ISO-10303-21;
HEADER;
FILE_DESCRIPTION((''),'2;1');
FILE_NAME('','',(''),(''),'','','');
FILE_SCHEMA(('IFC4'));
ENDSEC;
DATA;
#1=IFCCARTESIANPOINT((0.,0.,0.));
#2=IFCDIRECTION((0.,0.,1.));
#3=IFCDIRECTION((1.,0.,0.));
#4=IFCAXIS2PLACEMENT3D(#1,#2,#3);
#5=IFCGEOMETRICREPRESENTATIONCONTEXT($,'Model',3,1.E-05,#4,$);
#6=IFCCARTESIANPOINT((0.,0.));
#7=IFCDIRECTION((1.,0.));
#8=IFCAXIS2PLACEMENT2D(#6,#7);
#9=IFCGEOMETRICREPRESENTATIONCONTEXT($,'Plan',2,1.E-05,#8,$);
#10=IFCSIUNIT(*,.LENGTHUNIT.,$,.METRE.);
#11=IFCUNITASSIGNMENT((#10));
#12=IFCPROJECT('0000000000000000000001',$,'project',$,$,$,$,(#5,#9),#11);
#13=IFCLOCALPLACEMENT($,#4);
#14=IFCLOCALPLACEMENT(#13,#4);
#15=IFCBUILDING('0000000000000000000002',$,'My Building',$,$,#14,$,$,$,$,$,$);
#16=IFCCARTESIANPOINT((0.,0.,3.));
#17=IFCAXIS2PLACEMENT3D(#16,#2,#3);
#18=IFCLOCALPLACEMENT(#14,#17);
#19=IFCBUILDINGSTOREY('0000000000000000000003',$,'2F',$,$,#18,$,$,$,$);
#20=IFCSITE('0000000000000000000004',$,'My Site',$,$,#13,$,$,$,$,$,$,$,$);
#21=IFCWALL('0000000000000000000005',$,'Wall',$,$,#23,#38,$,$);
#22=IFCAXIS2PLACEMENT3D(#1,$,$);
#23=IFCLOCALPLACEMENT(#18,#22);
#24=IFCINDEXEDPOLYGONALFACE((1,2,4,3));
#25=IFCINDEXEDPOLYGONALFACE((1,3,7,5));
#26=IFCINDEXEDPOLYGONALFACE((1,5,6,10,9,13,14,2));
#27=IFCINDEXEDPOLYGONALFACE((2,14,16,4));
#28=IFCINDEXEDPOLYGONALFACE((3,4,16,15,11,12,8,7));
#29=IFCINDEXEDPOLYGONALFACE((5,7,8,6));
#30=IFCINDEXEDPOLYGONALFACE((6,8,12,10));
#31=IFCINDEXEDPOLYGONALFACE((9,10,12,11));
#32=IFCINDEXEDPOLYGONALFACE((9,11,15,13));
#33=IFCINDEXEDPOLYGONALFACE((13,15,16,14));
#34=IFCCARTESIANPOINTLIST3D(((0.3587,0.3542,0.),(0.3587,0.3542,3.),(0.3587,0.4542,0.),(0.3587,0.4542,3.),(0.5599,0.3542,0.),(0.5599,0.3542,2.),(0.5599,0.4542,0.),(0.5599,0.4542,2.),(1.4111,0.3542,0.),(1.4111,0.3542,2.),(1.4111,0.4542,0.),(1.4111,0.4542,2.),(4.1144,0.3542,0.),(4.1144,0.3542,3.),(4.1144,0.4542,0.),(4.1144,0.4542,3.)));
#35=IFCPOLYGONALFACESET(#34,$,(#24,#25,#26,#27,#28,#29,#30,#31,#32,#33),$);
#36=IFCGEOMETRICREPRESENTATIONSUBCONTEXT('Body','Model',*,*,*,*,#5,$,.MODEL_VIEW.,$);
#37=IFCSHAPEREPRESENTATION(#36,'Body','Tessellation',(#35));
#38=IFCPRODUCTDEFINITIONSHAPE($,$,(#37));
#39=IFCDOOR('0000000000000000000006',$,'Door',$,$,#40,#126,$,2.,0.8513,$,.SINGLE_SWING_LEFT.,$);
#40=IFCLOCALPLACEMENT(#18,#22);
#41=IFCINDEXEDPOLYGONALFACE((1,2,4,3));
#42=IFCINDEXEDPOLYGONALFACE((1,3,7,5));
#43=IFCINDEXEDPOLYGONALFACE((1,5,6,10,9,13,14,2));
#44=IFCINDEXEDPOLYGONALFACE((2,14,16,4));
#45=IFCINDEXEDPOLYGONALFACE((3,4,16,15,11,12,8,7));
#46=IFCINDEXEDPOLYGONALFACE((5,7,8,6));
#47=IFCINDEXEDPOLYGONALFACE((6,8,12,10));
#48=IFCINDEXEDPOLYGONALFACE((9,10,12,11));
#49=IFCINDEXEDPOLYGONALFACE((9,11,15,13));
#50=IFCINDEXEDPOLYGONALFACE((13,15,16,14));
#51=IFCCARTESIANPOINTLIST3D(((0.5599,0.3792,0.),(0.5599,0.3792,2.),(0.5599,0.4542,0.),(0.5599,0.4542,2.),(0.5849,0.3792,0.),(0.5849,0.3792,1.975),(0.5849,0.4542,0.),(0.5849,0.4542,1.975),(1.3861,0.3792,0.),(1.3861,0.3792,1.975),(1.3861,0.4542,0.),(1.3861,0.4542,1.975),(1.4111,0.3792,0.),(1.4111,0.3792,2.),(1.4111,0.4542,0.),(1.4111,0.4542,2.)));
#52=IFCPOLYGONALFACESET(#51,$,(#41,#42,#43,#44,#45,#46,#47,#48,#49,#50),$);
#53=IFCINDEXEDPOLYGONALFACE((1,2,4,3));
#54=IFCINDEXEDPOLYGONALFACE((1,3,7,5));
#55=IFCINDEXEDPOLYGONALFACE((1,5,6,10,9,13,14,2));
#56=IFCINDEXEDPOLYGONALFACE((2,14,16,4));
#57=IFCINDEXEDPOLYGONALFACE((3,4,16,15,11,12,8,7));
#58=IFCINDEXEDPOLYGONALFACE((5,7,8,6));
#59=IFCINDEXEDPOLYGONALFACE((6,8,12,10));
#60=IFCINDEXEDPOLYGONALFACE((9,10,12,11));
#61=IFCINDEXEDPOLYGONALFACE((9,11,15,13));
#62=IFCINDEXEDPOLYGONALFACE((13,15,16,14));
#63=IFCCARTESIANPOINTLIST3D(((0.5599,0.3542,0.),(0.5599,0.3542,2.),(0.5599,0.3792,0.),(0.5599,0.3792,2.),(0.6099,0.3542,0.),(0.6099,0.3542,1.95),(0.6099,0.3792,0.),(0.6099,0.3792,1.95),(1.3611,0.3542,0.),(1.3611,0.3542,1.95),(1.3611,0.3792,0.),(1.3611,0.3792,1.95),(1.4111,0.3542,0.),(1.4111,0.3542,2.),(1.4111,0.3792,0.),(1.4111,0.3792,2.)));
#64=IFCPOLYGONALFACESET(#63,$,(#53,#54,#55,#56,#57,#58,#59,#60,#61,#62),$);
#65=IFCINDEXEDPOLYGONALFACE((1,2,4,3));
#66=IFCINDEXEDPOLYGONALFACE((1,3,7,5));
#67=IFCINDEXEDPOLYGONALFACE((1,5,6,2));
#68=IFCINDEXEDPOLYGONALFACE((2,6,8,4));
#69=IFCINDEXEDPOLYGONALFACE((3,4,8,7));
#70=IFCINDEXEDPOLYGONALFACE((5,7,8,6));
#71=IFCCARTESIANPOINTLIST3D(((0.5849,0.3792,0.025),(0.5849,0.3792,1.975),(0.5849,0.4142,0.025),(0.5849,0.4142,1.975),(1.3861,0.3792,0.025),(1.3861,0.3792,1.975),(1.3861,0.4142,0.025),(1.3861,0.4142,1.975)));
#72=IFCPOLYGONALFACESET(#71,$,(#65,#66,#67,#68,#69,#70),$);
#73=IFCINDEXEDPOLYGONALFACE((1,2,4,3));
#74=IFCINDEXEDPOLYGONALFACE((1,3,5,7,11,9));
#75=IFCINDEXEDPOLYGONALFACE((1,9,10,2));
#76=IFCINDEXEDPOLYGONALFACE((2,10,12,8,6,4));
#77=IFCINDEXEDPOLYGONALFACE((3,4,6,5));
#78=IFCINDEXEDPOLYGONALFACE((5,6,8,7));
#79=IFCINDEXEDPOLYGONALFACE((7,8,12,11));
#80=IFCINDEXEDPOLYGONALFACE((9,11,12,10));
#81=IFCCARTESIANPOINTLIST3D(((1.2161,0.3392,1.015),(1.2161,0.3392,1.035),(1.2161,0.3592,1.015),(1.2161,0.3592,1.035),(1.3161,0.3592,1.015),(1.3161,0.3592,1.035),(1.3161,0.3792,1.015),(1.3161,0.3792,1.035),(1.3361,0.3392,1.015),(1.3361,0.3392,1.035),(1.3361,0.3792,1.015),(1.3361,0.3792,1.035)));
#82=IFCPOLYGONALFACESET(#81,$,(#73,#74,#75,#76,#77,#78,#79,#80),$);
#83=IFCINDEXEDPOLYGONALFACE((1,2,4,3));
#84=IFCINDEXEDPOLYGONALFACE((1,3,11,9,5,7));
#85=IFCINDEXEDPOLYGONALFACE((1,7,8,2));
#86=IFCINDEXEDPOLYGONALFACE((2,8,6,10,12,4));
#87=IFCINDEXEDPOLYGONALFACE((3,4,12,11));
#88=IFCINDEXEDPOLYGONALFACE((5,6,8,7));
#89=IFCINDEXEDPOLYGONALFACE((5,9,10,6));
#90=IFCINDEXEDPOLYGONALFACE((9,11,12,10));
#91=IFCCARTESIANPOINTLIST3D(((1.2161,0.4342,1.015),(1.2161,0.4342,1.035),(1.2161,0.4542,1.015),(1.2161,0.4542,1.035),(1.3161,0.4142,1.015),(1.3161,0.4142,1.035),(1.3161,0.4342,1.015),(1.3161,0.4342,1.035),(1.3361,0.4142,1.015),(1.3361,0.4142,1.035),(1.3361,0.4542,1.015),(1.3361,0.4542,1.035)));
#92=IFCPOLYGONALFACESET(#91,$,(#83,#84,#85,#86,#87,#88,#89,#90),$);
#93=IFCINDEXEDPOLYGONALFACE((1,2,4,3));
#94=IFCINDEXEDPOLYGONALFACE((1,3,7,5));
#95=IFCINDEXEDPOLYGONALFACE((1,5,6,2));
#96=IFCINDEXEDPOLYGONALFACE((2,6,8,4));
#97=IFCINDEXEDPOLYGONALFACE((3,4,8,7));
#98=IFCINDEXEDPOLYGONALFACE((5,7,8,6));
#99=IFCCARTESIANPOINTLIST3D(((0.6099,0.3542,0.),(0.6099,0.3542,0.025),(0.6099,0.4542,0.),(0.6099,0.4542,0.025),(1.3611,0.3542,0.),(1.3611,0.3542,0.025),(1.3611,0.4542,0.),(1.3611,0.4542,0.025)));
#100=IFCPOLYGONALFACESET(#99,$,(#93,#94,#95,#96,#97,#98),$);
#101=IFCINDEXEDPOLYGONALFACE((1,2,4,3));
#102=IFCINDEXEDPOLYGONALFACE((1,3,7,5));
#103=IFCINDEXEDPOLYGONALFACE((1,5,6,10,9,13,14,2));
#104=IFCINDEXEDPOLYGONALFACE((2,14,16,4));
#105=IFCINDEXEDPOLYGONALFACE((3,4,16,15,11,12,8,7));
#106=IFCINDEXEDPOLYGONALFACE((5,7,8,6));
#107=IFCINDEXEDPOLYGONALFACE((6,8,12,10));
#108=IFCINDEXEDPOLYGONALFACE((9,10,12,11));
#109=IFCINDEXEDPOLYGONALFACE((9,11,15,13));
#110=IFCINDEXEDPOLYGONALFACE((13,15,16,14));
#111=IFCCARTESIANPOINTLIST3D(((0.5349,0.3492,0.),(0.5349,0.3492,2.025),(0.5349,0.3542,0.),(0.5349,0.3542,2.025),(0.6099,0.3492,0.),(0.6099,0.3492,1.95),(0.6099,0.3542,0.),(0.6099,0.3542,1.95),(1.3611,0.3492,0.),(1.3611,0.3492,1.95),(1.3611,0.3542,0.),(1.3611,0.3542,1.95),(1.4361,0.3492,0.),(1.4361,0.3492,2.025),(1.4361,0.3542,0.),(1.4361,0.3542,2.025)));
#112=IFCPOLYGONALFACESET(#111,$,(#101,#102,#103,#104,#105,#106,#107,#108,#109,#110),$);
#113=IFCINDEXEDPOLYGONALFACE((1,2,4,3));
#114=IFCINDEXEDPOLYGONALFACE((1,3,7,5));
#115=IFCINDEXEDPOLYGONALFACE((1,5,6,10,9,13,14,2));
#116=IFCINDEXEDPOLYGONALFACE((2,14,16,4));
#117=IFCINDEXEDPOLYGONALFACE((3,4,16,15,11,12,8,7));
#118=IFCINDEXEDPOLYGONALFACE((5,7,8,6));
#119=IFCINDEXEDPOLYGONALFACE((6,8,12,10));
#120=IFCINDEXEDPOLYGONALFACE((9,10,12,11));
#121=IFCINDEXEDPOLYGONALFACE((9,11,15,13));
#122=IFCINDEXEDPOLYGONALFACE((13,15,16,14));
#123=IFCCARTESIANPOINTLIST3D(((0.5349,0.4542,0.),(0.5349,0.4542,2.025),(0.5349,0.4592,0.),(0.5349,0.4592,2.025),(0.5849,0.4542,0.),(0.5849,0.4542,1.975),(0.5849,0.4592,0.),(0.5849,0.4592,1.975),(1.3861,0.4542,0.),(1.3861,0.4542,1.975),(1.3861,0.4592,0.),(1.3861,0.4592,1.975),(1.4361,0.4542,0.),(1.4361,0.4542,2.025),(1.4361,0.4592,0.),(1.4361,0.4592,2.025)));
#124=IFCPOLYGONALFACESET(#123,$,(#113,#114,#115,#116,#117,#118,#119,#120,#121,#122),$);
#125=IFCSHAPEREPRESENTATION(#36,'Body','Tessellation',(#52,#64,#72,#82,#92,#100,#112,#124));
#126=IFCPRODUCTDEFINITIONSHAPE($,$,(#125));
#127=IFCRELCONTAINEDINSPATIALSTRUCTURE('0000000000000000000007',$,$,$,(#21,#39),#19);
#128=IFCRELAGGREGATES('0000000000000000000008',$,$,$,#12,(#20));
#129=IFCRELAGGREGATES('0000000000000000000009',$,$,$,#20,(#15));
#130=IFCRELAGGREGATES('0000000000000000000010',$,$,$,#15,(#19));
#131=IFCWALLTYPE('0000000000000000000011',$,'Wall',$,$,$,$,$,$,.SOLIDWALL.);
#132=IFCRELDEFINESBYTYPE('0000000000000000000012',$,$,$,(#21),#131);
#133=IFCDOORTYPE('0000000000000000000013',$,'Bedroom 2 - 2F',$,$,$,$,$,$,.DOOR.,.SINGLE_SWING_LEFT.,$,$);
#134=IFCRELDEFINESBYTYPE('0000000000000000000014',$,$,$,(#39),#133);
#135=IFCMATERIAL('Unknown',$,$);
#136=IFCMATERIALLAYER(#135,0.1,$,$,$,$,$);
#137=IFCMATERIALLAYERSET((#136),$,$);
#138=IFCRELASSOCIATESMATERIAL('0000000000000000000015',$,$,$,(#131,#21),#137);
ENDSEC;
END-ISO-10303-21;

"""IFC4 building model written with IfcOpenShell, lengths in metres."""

from ifc_helpers import new_model, entity, si_unit, frame, origin_with_axes, origin_2d_with_axis, place, context, subcontext, project, spatial, line, indexed_curve, outline, extrude, shape, source, transform, mapped, material, layer, layer_set, layer_usage, type_object, type_shapes, element, fill, save


model = new_model("IFC4")

# Units and contexts
model_context = context("Model", 3, precision=1e-05, world=origin_with_axes())
plan_context = context("Plan", 2, precision=1e-05, world=origin_2d_with_axis())
body_context_1 = subcontext(model_context, "Body", "Model", "MODEL_VIEW")
body_context_2 = subcontext(plan_context, "Body", "Plan", "PLAN_VIEW")
ifc_project = project(units=[si_unit("LENGTHUNIT", "METRE")], contexts=[model_context, plan_context])

# Site, building, storey
site_placement = place(None, origin_with_axes())
site = spatial("IfcSite", under=ifc_project, at=site_placement, Name="My Site")
building_placement = place(site_placement, origin_with_axes())
building = spatial("IfcBuilding", under=site, at=building_placement, Name="My Building")
storey_placement = place(building_placement, frame((0.0, 0.0, 3.0), z_axis=(0.0, 0.0, 1.0), x_axis=(1.0, 0.0, 0.0)))
storey = spatial("IfcBuildingStorey", under=building, at=storey_placement, Name="2F")

# Shared definitions
ifc_material = material(Name="Unknown")

# Shared definitions
ifc_layer_1 = layer(ifc_material, 0.1)
ifc_layer_set_1 = layer_set([ifc_layer_1])
wall_type = type_object("IfcWallType", Name="Wall", PredefinedType="SOLIDWALL", material=ifc_layer_set_1)

# Shared definitions
shared_shape_1 = source(origin_with_axes(), body_context_1, "Body", "SweptSolid", [
    extrude(outline(indexed_curve([(0.0, 0.0), (0.8513, 0.0), (0.8513, 2.0), (0.0, 2.0)], segments=[line(1, 2, 3, 4, 1)])), frame((0.0, -0.6, 0.0), z_axis=(0.0, -1.0, 0.0), x_axis=(1.0, 0.0, 0.0)), (0.0, 0.0, -1.0), 1.2),
])
door_type_1 = type_object("IfcDoorType", Name="Bedroom 2 - 2F", OperationType="SINGLE_SWING_LEFT", PredefinedType="DOOR")
shared_shape_2 = source(origin_with_axes(), body_context_1, "Body", "SweptSolid", [
    extrude(outline(indexed_curve([(0.0, 0.0), (0.0, 2.0), (0.8513, 2.0), (0.8513, 0.0), (0.8263, 0.0), (0.8263, 1.975), (0.025, 1.975), (0.025, 0.0)], segments=[line(1, 2, 3, 4, 5, 6, 7, 8, 1)])), frame((0.0, 0.025, 0.0), z_axis=(0.0, -1.0, 0.0), x_axis=(1.0, 0.0, 0.0)), (0.0, 0.0, -1.0), 0.075),
    extrude(outline(indexed_curve([(0.0, 0.0), (0.0, 2.0), (0.8513, 2.0), (0.8513, 0.0), (0.8013, 0.0), (0.8013, 1.95), (0.05, 1.95), (0.05, 0.0)], segments=[line(1, 2, 3, 4, 5, 6, 7, 8, 1)])), frame((0.0, 0.0, 0.0), z_axis=(0.0, -1.0, 0.0), x_axis=(1.0, 0.0, 0.0)), (0.0, 0.0, -1.0), 0.025),
    extrude(outline(indexed_curve([(0.0, 0.0), (0.8013, 0.0), (0.8013, 0.035), (0.0, 0.035)], segments=[line(1, 2, 3, 4, 1)])), frame((0.025, 0.025, 0.025), z_axis=(0.0, 0.0, 1.0), x_axis=(1.0, 0.0, 0.0)), (0.0, 0.0, 1.0), 1.95),
    extrude(outline(indexed_curve([(0.0, 0.0), (0.0, -0.04), (-0.12, -0.04), (-0.12, -0.02), (-0.02, -0.02), (-0.02, 0.0)], segments=[line(1, 2, 3, 4, 5, 6, 1)])), frame((0.7763, 0.025, 1.015), z_axis=(0.0, 0.0, 1.0), x_axis=(1.0, 0.0, 0.0)), (0.0, 0.0, 1.0), 0.02),
    extrude(outline(indexed_curve([(0.0, 0.0), (0.0, 0.04), (-0.12, 0.04), (-0.12, 0.02), (-0.02, 0.02), (-0.02, 0.0)], segments=[line(1, 2, 3, 4, 5, 6, 1)])), frame((0.7763, 0.06, 1.015), z_axis=(0.0, 0.0, 1.0), x_axis=(1.0, 0.0, 0.0)), (0.0, 0.0, 1.0), 0.02),
    extrude(outline(indexed_curve([(0.0, 0.0), (0.7513, 0.0), (0.7513, 0.1), (0.0, 0.1)], segments=[line(1, 2, 3, 4, 1)])), frame((0.05, 0.0, 0.0), z_axis=(0.0, 0.0, 1.0), x_axis=(1.0, 0.0, 0.0)), (0.0, 0.0, 1.0), 0.025),
    extrude(outline(indexed_curve([(0.0, 0.0), (0.0, 2.025), (0.9013, 2.025), (0.9013, 0.0), (0.8263, 0.0), (0.8263, 1.95), (0.075, 1.95), (0.075, 0.0)], segments=[line(1, 2, 3, 4, 5, 6, 7, 8, 1)])), frame((-0.025, -0.005, 0.0), z_axis=(0.0, -1.0, 0.0), x_axis=(1.0, 0.0, 0.0)), (0.0, 0.0, -1.0), 0.005),
    extrude(outline(indexed_curve([(0.0, 0.0), (0.0, 2.025), (0.9013, 2.025), (0.9013, 0.0), (0.8513, 0.0), (0.8513, 1.975), (0.05, 1.975), (0.05, 0.0)], segments=[line(1, 2, 3, 4, 5, 6, 7, 8, 1)])), frame((-0.025, 0.1, 0.0), z_axis=(0.0, -1.0, 0.0), x_axis=(1.0, 0.0, 0.0)), (0.0, 0.0, -1.0), 0.005),
])
shared_shape_3 = source(origin_with_axes(), body_context_2, "Body", "Curve2D", [
    entity("IfcIndexedPolyCurve", entity("IfcCartesianPointList2D", [[0.0, 0.0], [0.0, 0.1], [0.025, 0.1], [0.025, 0.025], [0.05, 0.025], [0.05, 0.0]]), [entity("IfcLineIndex", [1, 2, 3, 4, 5, 6, 1])]),
    entity("IfcIndexedPolyCurve", entity("IfcCartesianPointList2D", [[0.8513, 0.0], [0.8513, 0.1], [0.8263, 0.1], [0.8263, 0.025], [0.8013, 0.025], [0.8013, 0.0]]), [entity("IfcLineIndex", [1, 2, 3, 4, 5, 6, 1])]),
    entity("IfcTrimmedCurve", entity("IfcEllipse", entity("IfcAxis2Placement2D", entity("IfcCartesianPoint", [0.06, 0.1]), entity("IfcDirection", [1.0, 0.0])), 0.7663, 0.8013), [entity("IfcCartesianPoint", [0.8263, 0.1])], [entity("IfcCartesianPoint", [0.06, 0.9013])], True, "CARTESIAN"),
    entity("IfcIndexedPolyCurve", entity("IfcCartesianPointList2D", [[0.025, 0.1], [0.06, 0.1], [0.06, 0.9013], [0.025, 0.9013]]), [entity("IfcLineIndex", [1, 2, 3, 4, 1])]),
])
type_shapes(door_type_1, [shared_shape_2, shared_shape_3])

# Wall, opening, door
ifc_layer_usage_1 = layer_usage(ifc_layer_set_1, "AXIS2", "POSITIVE", 0.0)
wall_1_placement = place(storey_placement, frame((4.1144, 0.4542, 0.0), z_axis=(0.0, 0.0, 1.0), x_axis=(-1.0, 0.0, 0.0)))
wall_1 = element("IfcWall", 1, at=wall_1_placement, inside=storey, type_object=wall_type, material=ifc_layer_usage_1, Name="Wall", context=body_context_1, shape_type="SweptSolid", body=[
    extrude(outline(indexed_curve([(0.0, 0.0), (0.0, 0.1), (3.7557, 0.1), (3.7557, 0.0)], segments=[line(1, 2, 3, 4, 1)])), origin_with_axes(), (0.0, 0.0, 1.0), 3.0),
])
opening_1_placement = place(wall_1_placement, frame((3.5545, 0.1, 0.0), z_axis=(0.0, 0.0, 1.0), x_axis=(-1.0, 0.0, 0.0)))
opening_1 = element("IfcOpeningElement", 2, at=opening_1_placement, cuts=wall_1, PredefinedType="OPENING", context=body_context_1, shape_type="MappedRepresentation", body=[
    mapped(shared_shape_1, transform((0.0, 0.0, 0.0), x_axis=(1.0, 0.0, 0.0), y_axis=(0.0, 1.0, 0.0), z_axis=(0.0, 0.0, 1.0), scale=1.0)),
])
door_1_placement = place(opening_1_placement, frame((0.0, 0.0, 0.0), z_axis=(0.0, 0.0, 1.0), x_axis=(1.0, 0.0, 0.0)))
door_1 = element("IfcDoor", 3, at=door_1_placement, inside=storey, type_object=door_type_1, Name="Door", OperationType="SINGLE_SWING_LEFT", OverallHeight=2.0, OverallWidth=0.8513, shapes=[
    shape(body_context_1, "Body", "MappedRepresentation", [mapped(shared_shape_2, transform((0.0, 0.0, 0.0), x_axis=(1.0, 0.0, 0.0), y_axis=(0.0, 1.0, 0.0), z_axis=(0.0, 0.0, 1.0), scale=1.0))]),
    shape(body_context_2, "Body", "MappedRepresentation", [mapped(shared_shape_3, transform((0.0, 0.0, 0.0), x_axis=(1.0, 0.0, 0.0), y_axis=(0.0, 1.0, 0.0), z_axis=(0.0, 0.0, 1.0), scale=1.0))]),
])
fill(opening_1, door_1)

save(model, "model.ifc")
